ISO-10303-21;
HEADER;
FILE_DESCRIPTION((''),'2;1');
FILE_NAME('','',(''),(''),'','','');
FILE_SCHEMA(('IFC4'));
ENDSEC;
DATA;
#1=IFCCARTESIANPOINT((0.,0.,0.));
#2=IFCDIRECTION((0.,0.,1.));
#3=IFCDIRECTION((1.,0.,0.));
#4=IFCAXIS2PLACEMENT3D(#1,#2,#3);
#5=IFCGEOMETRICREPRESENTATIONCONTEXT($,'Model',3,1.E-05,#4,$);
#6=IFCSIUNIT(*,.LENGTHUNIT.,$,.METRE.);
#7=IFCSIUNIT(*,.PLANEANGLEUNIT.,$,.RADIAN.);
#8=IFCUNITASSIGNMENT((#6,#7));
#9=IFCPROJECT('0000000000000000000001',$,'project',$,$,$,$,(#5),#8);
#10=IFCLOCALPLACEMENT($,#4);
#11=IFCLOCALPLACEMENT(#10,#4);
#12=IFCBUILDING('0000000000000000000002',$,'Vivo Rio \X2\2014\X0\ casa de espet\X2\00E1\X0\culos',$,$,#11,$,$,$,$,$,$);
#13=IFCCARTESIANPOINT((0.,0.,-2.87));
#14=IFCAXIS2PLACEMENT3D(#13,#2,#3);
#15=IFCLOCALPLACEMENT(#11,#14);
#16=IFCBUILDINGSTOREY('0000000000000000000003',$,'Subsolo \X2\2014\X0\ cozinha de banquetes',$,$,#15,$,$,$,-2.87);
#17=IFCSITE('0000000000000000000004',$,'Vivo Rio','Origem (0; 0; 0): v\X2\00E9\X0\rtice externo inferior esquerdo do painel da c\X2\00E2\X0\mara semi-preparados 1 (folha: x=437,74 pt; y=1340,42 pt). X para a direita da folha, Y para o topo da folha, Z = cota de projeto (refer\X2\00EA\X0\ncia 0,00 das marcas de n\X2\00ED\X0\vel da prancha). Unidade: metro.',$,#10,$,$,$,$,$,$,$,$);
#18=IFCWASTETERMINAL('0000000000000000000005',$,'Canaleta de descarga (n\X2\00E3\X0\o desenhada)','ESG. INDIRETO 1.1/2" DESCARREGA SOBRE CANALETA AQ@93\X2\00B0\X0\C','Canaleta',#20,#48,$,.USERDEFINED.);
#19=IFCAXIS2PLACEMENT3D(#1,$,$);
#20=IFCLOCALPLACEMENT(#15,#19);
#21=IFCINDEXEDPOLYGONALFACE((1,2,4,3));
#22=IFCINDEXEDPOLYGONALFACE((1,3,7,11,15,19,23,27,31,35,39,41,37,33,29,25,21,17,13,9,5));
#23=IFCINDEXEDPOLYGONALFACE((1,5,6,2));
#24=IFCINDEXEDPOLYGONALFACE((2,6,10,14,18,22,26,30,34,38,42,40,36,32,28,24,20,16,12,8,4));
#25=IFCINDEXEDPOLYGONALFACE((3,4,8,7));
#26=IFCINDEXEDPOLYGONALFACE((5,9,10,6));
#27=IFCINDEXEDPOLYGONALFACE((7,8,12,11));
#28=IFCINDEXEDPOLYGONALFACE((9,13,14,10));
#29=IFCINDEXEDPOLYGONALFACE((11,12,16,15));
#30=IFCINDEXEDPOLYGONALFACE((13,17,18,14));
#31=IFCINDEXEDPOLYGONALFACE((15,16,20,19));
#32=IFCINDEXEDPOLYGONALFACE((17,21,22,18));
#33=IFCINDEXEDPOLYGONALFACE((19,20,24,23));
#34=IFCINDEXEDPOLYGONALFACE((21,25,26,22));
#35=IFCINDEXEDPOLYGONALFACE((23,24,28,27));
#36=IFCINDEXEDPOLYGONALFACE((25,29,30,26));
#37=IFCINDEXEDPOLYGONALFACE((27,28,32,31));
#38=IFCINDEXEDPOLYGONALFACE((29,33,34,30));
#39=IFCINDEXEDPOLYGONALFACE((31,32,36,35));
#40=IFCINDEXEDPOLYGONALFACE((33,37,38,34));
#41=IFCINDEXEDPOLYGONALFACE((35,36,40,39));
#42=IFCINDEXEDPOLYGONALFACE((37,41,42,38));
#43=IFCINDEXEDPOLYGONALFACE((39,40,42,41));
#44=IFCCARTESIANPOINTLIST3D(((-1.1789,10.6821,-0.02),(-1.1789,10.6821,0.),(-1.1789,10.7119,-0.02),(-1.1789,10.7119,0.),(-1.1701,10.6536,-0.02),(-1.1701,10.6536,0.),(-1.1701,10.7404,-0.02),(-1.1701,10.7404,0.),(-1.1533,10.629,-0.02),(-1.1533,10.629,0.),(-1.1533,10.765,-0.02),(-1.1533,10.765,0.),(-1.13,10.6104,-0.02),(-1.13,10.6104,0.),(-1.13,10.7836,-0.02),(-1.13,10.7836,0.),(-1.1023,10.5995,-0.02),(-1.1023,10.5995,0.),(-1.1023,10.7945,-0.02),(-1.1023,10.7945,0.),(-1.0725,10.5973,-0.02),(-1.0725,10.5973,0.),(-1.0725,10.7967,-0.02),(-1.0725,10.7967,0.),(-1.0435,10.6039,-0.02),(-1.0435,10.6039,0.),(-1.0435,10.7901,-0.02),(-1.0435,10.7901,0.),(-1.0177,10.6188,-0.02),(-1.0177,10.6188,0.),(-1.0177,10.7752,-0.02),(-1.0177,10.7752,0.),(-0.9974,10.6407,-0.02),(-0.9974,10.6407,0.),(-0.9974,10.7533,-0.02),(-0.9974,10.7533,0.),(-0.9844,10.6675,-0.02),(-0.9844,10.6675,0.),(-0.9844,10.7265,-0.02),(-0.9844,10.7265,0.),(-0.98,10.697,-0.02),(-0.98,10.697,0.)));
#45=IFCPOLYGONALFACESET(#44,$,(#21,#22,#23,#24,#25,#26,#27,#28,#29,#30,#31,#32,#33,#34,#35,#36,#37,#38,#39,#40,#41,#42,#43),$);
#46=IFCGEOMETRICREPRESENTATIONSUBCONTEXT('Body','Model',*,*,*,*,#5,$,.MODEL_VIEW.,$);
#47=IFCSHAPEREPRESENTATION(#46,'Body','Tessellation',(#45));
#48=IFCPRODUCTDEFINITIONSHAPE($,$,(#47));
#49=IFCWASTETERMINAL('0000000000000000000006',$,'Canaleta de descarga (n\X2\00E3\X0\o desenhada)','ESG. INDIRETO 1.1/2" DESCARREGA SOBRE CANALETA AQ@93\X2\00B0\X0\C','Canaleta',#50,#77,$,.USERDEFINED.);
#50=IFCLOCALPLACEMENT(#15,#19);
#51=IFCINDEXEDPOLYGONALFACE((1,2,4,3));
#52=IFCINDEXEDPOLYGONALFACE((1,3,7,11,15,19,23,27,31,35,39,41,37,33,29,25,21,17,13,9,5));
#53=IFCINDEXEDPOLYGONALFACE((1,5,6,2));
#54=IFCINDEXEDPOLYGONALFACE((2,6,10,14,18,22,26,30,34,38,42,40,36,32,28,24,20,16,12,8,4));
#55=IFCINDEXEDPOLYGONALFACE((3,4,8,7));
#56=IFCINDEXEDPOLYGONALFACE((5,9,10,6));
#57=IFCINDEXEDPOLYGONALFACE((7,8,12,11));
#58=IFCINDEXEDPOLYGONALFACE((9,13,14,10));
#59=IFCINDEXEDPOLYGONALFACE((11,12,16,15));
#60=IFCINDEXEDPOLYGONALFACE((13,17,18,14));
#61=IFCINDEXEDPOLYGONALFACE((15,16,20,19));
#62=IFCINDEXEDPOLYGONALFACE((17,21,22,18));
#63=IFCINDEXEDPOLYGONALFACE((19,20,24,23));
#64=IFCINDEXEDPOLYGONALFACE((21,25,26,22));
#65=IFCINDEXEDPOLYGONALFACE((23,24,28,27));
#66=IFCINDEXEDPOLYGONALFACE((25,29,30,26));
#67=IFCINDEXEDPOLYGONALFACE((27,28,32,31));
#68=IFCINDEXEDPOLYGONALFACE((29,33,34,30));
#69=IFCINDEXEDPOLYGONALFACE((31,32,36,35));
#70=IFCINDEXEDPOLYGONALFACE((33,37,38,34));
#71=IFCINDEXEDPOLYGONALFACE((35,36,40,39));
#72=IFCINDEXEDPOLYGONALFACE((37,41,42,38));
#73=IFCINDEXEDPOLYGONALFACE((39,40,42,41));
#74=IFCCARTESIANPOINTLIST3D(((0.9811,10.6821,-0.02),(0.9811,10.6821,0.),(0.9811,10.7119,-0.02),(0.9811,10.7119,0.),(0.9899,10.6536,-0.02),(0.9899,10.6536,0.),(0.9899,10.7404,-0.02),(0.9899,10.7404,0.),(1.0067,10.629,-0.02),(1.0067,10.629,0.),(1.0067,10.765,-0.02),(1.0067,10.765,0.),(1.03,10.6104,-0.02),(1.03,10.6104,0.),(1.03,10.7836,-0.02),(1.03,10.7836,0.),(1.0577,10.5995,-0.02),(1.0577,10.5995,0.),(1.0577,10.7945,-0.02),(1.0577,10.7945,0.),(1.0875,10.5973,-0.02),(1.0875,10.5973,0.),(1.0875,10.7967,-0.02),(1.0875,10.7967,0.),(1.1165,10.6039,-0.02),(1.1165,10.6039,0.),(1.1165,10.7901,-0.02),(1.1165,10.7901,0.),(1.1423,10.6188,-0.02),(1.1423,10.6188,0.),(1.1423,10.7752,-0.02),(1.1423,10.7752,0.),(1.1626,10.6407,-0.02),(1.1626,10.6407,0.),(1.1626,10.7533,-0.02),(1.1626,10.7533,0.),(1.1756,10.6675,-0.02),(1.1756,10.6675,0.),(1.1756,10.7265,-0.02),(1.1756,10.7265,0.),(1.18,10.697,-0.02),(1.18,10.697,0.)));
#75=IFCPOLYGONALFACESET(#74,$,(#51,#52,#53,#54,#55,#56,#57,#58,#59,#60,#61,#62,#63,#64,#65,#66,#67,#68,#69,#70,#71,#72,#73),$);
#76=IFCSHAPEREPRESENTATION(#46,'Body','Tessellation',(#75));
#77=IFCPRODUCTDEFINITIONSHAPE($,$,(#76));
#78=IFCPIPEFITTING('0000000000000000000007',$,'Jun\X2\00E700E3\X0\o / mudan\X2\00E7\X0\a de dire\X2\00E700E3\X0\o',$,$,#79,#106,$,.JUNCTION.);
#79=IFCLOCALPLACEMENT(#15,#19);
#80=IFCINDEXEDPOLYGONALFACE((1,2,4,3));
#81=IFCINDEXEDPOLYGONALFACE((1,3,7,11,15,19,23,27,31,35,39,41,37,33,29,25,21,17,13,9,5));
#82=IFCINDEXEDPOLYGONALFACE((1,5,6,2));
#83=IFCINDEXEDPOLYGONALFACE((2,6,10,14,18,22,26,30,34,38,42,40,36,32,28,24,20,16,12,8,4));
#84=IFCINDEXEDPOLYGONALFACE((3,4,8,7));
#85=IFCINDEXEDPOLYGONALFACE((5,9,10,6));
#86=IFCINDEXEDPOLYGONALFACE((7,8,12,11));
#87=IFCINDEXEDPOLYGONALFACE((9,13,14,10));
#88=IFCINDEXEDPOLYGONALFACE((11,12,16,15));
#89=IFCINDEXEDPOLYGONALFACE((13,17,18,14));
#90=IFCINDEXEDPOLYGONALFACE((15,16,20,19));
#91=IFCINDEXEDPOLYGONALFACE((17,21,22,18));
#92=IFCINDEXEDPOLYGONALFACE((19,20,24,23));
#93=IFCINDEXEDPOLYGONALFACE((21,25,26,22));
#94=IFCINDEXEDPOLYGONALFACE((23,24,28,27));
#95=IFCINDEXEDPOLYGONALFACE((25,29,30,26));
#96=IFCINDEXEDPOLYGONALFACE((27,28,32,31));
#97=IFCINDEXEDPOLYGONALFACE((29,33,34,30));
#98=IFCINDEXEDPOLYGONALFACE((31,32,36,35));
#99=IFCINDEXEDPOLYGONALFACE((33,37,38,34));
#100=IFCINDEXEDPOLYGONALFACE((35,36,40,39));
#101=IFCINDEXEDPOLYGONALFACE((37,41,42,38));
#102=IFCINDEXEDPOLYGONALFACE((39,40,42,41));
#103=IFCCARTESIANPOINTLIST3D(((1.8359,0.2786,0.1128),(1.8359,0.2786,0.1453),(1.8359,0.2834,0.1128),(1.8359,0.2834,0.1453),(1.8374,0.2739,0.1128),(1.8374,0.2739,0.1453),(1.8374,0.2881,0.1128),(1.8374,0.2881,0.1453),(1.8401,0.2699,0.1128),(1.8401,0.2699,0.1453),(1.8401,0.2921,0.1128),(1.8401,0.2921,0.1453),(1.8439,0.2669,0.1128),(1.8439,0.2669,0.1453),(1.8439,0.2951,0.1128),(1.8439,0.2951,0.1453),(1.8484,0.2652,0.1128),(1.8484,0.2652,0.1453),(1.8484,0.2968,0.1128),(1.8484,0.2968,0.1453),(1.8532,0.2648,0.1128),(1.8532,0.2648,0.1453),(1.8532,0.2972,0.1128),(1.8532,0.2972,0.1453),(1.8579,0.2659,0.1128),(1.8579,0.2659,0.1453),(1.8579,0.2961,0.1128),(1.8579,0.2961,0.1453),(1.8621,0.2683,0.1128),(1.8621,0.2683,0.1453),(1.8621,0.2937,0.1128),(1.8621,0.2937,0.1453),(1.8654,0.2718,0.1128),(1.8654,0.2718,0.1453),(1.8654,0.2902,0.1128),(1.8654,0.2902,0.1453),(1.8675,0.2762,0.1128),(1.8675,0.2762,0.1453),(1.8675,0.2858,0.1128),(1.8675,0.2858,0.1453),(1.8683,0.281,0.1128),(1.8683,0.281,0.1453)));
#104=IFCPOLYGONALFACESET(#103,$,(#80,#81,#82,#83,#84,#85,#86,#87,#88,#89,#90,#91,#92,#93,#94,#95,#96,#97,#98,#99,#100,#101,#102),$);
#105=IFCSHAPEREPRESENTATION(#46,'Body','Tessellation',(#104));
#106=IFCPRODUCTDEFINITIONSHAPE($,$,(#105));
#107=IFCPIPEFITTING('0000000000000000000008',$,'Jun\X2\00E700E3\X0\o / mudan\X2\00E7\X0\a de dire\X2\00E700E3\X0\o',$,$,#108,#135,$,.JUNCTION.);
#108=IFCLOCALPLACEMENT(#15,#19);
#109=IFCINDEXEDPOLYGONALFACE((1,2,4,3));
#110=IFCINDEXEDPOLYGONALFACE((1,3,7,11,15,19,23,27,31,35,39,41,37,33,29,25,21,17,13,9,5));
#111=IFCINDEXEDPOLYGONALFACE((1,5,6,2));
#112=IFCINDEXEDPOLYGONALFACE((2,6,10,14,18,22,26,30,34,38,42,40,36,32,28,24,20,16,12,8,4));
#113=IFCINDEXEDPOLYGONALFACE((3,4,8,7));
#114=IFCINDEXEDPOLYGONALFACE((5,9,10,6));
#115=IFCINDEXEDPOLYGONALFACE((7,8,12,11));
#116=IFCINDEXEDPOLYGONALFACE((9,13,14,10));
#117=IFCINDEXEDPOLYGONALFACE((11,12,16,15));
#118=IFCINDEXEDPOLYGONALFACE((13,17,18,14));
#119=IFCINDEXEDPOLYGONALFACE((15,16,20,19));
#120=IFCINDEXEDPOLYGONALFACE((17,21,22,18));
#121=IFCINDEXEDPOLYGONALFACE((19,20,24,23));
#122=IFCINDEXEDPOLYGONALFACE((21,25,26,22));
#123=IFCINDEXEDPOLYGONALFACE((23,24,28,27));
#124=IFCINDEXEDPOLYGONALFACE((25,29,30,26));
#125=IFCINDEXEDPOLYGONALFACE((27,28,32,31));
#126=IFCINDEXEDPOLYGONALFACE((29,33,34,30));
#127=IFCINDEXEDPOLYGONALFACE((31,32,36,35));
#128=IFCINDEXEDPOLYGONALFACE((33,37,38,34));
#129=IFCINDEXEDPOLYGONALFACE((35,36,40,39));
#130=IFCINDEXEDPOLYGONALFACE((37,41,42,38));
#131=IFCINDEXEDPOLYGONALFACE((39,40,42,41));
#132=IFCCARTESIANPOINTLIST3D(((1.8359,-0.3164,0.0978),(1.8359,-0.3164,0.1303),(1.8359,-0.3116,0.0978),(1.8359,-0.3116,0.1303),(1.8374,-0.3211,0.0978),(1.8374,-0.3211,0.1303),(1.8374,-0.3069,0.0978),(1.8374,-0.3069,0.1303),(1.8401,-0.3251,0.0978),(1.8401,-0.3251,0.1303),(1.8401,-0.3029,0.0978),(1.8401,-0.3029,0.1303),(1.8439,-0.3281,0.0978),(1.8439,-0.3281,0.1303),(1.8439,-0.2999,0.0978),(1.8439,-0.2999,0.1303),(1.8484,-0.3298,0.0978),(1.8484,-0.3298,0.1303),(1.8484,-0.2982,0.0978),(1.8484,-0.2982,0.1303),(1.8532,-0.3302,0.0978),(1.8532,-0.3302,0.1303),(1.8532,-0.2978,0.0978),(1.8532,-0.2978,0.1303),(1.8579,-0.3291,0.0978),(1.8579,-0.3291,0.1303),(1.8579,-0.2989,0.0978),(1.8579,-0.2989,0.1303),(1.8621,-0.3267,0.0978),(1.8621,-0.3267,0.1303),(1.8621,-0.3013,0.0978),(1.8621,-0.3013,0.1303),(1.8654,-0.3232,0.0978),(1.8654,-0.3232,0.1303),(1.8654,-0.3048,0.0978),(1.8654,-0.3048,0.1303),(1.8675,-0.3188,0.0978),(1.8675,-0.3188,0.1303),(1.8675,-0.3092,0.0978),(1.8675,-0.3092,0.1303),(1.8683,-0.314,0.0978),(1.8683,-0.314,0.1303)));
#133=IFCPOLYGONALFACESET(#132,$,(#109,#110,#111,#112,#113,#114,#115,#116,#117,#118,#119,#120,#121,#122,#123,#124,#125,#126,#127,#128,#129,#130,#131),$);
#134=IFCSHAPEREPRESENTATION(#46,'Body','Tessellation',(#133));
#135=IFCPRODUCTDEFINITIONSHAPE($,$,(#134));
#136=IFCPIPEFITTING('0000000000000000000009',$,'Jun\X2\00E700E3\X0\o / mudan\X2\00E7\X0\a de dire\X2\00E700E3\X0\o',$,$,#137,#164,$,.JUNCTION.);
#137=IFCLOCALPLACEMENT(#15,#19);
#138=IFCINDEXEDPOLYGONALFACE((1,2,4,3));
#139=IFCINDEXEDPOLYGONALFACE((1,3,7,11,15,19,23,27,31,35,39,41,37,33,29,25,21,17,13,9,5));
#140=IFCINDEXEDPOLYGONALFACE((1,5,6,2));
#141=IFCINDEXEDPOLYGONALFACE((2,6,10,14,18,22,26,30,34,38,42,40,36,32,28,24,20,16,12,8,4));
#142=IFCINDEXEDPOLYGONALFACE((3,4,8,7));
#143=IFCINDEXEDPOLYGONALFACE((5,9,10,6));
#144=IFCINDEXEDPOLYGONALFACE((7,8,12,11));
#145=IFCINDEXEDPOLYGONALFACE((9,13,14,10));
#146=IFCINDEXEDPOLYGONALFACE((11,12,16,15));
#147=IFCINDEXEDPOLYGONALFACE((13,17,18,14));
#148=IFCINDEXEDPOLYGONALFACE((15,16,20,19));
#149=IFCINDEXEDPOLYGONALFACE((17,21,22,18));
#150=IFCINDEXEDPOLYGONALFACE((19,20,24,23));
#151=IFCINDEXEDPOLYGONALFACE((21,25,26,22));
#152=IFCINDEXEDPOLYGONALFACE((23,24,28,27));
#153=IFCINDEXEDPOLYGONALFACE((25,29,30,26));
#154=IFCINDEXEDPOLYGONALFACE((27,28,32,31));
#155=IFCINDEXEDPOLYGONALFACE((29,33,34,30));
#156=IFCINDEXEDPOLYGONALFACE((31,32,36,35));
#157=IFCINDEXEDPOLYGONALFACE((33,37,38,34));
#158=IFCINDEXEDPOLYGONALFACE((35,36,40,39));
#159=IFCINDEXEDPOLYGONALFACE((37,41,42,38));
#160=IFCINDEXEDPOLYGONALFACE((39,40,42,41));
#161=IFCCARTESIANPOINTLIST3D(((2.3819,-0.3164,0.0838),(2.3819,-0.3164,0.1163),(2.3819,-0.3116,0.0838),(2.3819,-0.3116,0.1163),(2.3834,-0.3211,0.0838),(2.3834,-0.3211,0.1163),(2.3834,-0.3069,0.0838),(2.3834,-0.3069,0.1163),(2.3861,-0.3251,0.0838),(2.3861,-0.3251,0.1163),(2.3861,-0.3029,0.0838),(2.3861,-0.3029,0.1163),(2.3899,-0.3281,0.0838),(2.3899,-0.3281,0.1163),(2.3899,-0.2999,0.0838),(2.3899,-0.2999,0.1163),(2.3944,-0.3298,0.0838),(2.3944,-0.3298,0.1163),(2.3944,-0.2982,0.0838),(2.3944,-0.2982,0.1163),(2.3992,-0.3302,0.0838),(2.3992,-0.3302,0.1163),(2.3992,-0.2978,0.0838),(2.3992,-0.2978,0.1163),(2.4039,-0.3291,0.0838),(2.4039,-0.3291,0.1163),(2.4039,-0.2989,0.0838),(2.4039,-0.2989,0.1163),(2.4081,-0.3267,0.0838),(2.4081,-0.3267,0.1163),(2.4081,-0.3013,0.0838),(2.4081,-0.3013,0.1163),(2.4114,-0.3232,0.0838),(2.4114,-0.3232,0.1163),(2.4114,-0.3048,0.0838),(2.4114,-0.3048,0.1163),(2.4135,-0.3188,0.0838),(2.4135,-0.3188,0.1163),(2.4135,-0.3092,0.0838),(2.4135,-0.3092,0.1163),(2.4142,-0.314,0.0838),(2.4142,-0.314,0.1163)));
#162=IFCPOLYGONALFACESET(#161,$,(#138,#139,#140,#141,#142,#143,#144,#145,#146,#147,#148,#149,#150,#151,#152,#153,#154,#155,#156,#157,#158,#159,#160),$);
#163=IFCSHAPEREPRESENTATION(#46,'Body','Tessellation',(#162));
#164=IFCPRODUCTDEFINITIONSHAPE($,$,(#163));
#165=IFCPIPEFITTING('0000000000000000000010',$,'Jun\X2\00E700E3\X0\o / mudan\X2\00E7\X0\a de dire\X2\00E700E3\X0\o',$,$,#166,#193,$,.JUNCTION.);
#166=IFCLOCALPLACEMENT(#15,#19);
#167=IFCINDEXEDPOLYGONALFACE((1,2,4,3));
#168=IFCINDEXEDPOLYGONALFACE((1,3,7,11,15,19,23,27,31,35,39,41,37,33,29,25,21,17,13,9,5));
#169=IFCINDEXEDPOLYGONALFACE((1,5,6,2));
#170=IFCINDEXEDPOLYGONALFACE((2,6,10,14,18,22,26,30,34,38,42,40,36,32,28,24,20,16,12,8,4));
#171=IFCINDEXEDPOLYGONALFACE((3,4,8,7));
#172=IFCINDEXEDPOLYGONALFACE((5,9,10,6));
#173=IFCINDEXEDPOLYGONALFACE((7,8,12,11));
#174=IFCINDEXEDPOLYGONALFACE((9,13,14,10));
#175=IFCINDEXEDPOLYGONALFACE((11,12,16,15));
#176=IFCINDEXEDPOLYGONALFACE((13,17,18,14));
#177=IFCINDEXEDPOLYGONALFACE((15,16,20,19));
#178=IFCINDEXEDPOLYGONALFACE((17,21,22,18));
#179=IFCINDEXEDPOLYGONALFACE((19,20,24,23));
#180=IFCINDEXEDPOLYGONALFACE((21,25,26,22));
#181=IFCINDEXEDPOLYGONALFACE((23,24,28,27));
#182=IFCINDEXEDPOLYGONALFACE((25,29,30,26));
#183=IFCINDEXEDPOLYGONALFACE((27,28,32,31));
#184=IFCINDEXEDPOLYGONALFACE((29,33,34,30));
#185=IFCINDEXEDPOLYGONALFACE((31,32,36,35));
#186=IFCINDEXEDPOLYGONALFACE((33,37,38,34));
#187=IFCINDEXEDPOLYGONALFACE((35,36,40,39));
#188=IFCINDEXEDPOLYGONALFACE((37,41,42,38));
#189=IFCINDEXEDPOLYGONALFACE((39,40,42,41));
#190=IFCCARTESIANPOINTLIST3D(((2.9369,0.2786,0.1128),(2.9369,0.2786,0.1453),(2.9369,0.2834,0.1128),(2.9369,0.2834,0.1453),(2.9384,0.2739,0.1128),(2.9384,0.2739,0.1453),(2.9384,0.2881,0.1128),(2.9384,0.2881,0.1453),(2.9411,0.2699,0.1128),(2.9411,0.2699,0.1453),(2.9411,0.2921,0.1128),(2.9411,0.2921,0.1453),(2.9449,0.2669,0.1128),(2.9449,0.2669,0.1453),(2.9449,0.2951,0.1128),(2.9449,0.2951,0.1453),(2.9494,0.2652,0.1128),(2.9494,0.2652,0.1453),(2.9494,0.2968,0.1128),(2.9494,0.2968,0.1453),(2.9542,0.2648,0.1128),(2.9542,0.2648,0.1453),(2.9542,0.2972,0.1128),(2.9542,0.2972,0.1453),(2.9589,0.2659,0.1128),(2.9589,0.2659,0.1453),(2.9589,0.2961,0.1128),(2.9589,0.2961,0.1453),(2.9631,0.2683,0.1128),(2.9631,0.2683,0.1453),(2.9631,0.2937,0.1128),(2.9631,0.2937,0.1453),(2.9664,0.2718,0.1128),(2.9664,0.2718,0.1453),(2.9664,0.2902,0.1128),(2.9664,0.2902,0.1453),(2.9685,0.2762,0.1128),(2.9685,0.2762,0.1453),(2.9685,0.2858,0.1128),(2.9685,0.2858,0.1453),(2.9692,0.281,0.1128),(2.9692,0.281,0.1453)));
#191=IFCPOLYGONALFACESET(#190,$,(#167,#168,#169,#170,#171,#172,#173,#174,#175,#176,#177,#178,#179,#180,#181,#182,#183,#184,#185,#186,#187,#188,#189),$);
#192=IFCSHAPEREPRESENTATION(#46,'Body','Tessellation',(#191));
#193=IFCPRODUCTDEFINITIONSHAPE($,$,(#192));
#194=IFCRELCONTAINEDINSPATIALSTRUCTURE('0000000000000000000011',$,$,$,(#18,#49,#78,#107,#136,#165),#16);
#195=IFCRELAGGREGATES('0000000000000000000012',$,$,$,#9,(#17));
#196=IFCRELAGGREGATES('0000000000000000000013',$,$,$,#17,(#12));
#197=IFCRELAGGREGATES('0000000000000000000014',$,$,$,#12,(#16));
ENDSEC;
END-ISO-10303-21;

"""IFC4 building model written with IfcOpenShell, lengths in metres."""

from ifc_helpers import new_model, si_unit, frame, origin_with_axes, origin_2d, place, context, subcontext, project, spatial, circle, extrude, element, save


model = new_model("IFC4")

# Units and contexts
model_context = context("Model", 3, precision=1e-05, world=origin_with_axes())
body_context = subcontext(model_context, "Body", "Model", "MODEL_VIEW")
ifc_project = project(units=[si_unit("LENGTHUNIT", "METRE"), si_unit("PLANEANGLEUNIT", "RADIAN")], contexts=[model_context])

# Site, building, storey
site_placement = place(None, origin_with_axes())
site = spatial("IfcSite", under=ifc_project, at=site_placement, Name="Vivo Rio", Description="Origem (0; 0; 0): vértice externo inferior esquerdo do painel da câmara semi-preparados 1 (folha: x=437,74 pt; y=1340,42 pt). X para a direita da folha, Y para o topo da folha, Z = cota de projeto (referência 0,00 das marcas de nível da prancha). Unidade: metro.")
building_placement = place(site_placement, origin_with_axes())
building = spatial("IfcBuilding", under=site, at=building_placement, Name="Vivo Rio — casa de espetáculos")
storey_placement = place(building_placement, frame((0.0, 0.0, -2.87), z_axis=(0.0, 0.0, 1.0), x_axis=(1.0, 0.0, 0.0)))
storey = spatial("IfcBuildingStorey", under=building, at=storey_placement, Name="Subsolo — cozinha de banquetes", Elevation=-2.87)

# Waste terminals
waste_terminal_1_placement = place(storey_placement, origin_with_axes())
element("IfcWasteTerminal", 1, at=waste_terminal_1_placement, inside=storey, Name="Canaleta de descarga (não desenhada)", Description="ESG. INDIRETO 1.1/2\" DESCARREGA SOBRE CANALETA AQ@93°C", ObjectType="Canaleta", PredefinedType="USERDEFINED", context=body_context, shape_type="SweptSolid", body=[
    extrude(circle(Radius=0.1, at=origin_2d()), frame((-1.08, 10.697, -0.02), z_axis=(0.0, 0.0, 1.0), x_axis=(1.0, 0.0, 0.0)), (0.0, 0.0, 1.0), 0.02),
])
waste_terminal_2_placement = place(storey_placement, origin_with_axes())
element("IfcWasteTerminal", 2, at=waste_terminal_2_placement, inside=storey, Name="Canaleta de descarga (não desenhada)", Description="ESG. INDIRETO 1.1/2\" DESCARREGA SOBRE CANALETA AQ@93°C", ObjectType="Canaleta", PredefinedType="USERDEFINED", context=body_context, shape_type="SweptSolid", body=[
    extrude(circle(Radius=0.1, at=origin_2d()), frame((1.08, 10.697, -0.02), z_axis=(0.0, 0.0, 1.0), x_axis=(1.0, 0.0, 0.0)), (0.0, 0.0, 1.0), 0.02),
])

# Pipe fittings
pipe_fitting_1_placement = place(storey_placement, origin_with_axes())
element("IfcPipeFitting", 3, at=pipe_fitting_1_placement, inside=storey, Name="Junção / mudança de direção", PredefinedType="JUNCTION", context=body_context, shape_type="SweptSolid", body=[
    extrude(circle(Radius=0.0163, at=origin_2d()), frame((1.852, 0.281, 0.1128), z_axis=(0.0, 0.0, 1.0), x_axis=(1.0, 0.0, 0.0)), (0.0, 0.0, 1.0), 0.0325),
])
pipe_fitting_2_placement = place(storey_placement, origin_with_axes())
element("IfcPipeFitting", 4, at=pipe_fitting_2_placement, inside=storey, Name="Junção / mudança de direção", PredefinedType="JUNCTION", context=body_context, shape_type="SweptSolid", body=[
    extrude(circle(Radius=0.0163, at=origin_2d()), frame((1.852, -0.314, 0.0978), z_axis=(0.0, 0.0, 1.0), x_axis=(1.0, 0.0, 0.0)), (0.0, 0.0, 1.0), 0.0325),
])
pipe_fitting_3_placement = place(storey_placement, origin_with_axes())
element("IfcPipeFitting", 5, at=pipe_fitting_3_placement, inside=storey, Name="Junção / mudança de direção", PredefinedType="JUNCTION", context=body_context, shape_type="SweptSolid", body=[
    extrude(circle(Radius=0.0163, at=origin_2d()), frame((2.398, -0.314, 0.0838), z_axis=(0.0, 0.0, 1.0), x_axis=(1.0, 0.0, 0.0)), (0.0, 0.0, 1.0), 0.0325),
])
pipe_fitting_4_placement = place(storey_placement, origin_with_axes())
element("IfcPipeFitting", 6, at=pipe_fitting_4_placement, inside=storey, Name="Junção / mudança de direção", PredefinedType="JUNCTION", context=body_context, shape_type="SweptSolid", body=[
    extrude(circle(Radius=0.0163, at=origin_2d()), frame((2.953, 0.281, 0.1128), z_axis=(0.0, 0.0, 1.0), x_axis=(1.0, 0.0, 0.0)), (0.0, 0.0, 1.0), 0.0325),
])

save(model, "model.ifc")
